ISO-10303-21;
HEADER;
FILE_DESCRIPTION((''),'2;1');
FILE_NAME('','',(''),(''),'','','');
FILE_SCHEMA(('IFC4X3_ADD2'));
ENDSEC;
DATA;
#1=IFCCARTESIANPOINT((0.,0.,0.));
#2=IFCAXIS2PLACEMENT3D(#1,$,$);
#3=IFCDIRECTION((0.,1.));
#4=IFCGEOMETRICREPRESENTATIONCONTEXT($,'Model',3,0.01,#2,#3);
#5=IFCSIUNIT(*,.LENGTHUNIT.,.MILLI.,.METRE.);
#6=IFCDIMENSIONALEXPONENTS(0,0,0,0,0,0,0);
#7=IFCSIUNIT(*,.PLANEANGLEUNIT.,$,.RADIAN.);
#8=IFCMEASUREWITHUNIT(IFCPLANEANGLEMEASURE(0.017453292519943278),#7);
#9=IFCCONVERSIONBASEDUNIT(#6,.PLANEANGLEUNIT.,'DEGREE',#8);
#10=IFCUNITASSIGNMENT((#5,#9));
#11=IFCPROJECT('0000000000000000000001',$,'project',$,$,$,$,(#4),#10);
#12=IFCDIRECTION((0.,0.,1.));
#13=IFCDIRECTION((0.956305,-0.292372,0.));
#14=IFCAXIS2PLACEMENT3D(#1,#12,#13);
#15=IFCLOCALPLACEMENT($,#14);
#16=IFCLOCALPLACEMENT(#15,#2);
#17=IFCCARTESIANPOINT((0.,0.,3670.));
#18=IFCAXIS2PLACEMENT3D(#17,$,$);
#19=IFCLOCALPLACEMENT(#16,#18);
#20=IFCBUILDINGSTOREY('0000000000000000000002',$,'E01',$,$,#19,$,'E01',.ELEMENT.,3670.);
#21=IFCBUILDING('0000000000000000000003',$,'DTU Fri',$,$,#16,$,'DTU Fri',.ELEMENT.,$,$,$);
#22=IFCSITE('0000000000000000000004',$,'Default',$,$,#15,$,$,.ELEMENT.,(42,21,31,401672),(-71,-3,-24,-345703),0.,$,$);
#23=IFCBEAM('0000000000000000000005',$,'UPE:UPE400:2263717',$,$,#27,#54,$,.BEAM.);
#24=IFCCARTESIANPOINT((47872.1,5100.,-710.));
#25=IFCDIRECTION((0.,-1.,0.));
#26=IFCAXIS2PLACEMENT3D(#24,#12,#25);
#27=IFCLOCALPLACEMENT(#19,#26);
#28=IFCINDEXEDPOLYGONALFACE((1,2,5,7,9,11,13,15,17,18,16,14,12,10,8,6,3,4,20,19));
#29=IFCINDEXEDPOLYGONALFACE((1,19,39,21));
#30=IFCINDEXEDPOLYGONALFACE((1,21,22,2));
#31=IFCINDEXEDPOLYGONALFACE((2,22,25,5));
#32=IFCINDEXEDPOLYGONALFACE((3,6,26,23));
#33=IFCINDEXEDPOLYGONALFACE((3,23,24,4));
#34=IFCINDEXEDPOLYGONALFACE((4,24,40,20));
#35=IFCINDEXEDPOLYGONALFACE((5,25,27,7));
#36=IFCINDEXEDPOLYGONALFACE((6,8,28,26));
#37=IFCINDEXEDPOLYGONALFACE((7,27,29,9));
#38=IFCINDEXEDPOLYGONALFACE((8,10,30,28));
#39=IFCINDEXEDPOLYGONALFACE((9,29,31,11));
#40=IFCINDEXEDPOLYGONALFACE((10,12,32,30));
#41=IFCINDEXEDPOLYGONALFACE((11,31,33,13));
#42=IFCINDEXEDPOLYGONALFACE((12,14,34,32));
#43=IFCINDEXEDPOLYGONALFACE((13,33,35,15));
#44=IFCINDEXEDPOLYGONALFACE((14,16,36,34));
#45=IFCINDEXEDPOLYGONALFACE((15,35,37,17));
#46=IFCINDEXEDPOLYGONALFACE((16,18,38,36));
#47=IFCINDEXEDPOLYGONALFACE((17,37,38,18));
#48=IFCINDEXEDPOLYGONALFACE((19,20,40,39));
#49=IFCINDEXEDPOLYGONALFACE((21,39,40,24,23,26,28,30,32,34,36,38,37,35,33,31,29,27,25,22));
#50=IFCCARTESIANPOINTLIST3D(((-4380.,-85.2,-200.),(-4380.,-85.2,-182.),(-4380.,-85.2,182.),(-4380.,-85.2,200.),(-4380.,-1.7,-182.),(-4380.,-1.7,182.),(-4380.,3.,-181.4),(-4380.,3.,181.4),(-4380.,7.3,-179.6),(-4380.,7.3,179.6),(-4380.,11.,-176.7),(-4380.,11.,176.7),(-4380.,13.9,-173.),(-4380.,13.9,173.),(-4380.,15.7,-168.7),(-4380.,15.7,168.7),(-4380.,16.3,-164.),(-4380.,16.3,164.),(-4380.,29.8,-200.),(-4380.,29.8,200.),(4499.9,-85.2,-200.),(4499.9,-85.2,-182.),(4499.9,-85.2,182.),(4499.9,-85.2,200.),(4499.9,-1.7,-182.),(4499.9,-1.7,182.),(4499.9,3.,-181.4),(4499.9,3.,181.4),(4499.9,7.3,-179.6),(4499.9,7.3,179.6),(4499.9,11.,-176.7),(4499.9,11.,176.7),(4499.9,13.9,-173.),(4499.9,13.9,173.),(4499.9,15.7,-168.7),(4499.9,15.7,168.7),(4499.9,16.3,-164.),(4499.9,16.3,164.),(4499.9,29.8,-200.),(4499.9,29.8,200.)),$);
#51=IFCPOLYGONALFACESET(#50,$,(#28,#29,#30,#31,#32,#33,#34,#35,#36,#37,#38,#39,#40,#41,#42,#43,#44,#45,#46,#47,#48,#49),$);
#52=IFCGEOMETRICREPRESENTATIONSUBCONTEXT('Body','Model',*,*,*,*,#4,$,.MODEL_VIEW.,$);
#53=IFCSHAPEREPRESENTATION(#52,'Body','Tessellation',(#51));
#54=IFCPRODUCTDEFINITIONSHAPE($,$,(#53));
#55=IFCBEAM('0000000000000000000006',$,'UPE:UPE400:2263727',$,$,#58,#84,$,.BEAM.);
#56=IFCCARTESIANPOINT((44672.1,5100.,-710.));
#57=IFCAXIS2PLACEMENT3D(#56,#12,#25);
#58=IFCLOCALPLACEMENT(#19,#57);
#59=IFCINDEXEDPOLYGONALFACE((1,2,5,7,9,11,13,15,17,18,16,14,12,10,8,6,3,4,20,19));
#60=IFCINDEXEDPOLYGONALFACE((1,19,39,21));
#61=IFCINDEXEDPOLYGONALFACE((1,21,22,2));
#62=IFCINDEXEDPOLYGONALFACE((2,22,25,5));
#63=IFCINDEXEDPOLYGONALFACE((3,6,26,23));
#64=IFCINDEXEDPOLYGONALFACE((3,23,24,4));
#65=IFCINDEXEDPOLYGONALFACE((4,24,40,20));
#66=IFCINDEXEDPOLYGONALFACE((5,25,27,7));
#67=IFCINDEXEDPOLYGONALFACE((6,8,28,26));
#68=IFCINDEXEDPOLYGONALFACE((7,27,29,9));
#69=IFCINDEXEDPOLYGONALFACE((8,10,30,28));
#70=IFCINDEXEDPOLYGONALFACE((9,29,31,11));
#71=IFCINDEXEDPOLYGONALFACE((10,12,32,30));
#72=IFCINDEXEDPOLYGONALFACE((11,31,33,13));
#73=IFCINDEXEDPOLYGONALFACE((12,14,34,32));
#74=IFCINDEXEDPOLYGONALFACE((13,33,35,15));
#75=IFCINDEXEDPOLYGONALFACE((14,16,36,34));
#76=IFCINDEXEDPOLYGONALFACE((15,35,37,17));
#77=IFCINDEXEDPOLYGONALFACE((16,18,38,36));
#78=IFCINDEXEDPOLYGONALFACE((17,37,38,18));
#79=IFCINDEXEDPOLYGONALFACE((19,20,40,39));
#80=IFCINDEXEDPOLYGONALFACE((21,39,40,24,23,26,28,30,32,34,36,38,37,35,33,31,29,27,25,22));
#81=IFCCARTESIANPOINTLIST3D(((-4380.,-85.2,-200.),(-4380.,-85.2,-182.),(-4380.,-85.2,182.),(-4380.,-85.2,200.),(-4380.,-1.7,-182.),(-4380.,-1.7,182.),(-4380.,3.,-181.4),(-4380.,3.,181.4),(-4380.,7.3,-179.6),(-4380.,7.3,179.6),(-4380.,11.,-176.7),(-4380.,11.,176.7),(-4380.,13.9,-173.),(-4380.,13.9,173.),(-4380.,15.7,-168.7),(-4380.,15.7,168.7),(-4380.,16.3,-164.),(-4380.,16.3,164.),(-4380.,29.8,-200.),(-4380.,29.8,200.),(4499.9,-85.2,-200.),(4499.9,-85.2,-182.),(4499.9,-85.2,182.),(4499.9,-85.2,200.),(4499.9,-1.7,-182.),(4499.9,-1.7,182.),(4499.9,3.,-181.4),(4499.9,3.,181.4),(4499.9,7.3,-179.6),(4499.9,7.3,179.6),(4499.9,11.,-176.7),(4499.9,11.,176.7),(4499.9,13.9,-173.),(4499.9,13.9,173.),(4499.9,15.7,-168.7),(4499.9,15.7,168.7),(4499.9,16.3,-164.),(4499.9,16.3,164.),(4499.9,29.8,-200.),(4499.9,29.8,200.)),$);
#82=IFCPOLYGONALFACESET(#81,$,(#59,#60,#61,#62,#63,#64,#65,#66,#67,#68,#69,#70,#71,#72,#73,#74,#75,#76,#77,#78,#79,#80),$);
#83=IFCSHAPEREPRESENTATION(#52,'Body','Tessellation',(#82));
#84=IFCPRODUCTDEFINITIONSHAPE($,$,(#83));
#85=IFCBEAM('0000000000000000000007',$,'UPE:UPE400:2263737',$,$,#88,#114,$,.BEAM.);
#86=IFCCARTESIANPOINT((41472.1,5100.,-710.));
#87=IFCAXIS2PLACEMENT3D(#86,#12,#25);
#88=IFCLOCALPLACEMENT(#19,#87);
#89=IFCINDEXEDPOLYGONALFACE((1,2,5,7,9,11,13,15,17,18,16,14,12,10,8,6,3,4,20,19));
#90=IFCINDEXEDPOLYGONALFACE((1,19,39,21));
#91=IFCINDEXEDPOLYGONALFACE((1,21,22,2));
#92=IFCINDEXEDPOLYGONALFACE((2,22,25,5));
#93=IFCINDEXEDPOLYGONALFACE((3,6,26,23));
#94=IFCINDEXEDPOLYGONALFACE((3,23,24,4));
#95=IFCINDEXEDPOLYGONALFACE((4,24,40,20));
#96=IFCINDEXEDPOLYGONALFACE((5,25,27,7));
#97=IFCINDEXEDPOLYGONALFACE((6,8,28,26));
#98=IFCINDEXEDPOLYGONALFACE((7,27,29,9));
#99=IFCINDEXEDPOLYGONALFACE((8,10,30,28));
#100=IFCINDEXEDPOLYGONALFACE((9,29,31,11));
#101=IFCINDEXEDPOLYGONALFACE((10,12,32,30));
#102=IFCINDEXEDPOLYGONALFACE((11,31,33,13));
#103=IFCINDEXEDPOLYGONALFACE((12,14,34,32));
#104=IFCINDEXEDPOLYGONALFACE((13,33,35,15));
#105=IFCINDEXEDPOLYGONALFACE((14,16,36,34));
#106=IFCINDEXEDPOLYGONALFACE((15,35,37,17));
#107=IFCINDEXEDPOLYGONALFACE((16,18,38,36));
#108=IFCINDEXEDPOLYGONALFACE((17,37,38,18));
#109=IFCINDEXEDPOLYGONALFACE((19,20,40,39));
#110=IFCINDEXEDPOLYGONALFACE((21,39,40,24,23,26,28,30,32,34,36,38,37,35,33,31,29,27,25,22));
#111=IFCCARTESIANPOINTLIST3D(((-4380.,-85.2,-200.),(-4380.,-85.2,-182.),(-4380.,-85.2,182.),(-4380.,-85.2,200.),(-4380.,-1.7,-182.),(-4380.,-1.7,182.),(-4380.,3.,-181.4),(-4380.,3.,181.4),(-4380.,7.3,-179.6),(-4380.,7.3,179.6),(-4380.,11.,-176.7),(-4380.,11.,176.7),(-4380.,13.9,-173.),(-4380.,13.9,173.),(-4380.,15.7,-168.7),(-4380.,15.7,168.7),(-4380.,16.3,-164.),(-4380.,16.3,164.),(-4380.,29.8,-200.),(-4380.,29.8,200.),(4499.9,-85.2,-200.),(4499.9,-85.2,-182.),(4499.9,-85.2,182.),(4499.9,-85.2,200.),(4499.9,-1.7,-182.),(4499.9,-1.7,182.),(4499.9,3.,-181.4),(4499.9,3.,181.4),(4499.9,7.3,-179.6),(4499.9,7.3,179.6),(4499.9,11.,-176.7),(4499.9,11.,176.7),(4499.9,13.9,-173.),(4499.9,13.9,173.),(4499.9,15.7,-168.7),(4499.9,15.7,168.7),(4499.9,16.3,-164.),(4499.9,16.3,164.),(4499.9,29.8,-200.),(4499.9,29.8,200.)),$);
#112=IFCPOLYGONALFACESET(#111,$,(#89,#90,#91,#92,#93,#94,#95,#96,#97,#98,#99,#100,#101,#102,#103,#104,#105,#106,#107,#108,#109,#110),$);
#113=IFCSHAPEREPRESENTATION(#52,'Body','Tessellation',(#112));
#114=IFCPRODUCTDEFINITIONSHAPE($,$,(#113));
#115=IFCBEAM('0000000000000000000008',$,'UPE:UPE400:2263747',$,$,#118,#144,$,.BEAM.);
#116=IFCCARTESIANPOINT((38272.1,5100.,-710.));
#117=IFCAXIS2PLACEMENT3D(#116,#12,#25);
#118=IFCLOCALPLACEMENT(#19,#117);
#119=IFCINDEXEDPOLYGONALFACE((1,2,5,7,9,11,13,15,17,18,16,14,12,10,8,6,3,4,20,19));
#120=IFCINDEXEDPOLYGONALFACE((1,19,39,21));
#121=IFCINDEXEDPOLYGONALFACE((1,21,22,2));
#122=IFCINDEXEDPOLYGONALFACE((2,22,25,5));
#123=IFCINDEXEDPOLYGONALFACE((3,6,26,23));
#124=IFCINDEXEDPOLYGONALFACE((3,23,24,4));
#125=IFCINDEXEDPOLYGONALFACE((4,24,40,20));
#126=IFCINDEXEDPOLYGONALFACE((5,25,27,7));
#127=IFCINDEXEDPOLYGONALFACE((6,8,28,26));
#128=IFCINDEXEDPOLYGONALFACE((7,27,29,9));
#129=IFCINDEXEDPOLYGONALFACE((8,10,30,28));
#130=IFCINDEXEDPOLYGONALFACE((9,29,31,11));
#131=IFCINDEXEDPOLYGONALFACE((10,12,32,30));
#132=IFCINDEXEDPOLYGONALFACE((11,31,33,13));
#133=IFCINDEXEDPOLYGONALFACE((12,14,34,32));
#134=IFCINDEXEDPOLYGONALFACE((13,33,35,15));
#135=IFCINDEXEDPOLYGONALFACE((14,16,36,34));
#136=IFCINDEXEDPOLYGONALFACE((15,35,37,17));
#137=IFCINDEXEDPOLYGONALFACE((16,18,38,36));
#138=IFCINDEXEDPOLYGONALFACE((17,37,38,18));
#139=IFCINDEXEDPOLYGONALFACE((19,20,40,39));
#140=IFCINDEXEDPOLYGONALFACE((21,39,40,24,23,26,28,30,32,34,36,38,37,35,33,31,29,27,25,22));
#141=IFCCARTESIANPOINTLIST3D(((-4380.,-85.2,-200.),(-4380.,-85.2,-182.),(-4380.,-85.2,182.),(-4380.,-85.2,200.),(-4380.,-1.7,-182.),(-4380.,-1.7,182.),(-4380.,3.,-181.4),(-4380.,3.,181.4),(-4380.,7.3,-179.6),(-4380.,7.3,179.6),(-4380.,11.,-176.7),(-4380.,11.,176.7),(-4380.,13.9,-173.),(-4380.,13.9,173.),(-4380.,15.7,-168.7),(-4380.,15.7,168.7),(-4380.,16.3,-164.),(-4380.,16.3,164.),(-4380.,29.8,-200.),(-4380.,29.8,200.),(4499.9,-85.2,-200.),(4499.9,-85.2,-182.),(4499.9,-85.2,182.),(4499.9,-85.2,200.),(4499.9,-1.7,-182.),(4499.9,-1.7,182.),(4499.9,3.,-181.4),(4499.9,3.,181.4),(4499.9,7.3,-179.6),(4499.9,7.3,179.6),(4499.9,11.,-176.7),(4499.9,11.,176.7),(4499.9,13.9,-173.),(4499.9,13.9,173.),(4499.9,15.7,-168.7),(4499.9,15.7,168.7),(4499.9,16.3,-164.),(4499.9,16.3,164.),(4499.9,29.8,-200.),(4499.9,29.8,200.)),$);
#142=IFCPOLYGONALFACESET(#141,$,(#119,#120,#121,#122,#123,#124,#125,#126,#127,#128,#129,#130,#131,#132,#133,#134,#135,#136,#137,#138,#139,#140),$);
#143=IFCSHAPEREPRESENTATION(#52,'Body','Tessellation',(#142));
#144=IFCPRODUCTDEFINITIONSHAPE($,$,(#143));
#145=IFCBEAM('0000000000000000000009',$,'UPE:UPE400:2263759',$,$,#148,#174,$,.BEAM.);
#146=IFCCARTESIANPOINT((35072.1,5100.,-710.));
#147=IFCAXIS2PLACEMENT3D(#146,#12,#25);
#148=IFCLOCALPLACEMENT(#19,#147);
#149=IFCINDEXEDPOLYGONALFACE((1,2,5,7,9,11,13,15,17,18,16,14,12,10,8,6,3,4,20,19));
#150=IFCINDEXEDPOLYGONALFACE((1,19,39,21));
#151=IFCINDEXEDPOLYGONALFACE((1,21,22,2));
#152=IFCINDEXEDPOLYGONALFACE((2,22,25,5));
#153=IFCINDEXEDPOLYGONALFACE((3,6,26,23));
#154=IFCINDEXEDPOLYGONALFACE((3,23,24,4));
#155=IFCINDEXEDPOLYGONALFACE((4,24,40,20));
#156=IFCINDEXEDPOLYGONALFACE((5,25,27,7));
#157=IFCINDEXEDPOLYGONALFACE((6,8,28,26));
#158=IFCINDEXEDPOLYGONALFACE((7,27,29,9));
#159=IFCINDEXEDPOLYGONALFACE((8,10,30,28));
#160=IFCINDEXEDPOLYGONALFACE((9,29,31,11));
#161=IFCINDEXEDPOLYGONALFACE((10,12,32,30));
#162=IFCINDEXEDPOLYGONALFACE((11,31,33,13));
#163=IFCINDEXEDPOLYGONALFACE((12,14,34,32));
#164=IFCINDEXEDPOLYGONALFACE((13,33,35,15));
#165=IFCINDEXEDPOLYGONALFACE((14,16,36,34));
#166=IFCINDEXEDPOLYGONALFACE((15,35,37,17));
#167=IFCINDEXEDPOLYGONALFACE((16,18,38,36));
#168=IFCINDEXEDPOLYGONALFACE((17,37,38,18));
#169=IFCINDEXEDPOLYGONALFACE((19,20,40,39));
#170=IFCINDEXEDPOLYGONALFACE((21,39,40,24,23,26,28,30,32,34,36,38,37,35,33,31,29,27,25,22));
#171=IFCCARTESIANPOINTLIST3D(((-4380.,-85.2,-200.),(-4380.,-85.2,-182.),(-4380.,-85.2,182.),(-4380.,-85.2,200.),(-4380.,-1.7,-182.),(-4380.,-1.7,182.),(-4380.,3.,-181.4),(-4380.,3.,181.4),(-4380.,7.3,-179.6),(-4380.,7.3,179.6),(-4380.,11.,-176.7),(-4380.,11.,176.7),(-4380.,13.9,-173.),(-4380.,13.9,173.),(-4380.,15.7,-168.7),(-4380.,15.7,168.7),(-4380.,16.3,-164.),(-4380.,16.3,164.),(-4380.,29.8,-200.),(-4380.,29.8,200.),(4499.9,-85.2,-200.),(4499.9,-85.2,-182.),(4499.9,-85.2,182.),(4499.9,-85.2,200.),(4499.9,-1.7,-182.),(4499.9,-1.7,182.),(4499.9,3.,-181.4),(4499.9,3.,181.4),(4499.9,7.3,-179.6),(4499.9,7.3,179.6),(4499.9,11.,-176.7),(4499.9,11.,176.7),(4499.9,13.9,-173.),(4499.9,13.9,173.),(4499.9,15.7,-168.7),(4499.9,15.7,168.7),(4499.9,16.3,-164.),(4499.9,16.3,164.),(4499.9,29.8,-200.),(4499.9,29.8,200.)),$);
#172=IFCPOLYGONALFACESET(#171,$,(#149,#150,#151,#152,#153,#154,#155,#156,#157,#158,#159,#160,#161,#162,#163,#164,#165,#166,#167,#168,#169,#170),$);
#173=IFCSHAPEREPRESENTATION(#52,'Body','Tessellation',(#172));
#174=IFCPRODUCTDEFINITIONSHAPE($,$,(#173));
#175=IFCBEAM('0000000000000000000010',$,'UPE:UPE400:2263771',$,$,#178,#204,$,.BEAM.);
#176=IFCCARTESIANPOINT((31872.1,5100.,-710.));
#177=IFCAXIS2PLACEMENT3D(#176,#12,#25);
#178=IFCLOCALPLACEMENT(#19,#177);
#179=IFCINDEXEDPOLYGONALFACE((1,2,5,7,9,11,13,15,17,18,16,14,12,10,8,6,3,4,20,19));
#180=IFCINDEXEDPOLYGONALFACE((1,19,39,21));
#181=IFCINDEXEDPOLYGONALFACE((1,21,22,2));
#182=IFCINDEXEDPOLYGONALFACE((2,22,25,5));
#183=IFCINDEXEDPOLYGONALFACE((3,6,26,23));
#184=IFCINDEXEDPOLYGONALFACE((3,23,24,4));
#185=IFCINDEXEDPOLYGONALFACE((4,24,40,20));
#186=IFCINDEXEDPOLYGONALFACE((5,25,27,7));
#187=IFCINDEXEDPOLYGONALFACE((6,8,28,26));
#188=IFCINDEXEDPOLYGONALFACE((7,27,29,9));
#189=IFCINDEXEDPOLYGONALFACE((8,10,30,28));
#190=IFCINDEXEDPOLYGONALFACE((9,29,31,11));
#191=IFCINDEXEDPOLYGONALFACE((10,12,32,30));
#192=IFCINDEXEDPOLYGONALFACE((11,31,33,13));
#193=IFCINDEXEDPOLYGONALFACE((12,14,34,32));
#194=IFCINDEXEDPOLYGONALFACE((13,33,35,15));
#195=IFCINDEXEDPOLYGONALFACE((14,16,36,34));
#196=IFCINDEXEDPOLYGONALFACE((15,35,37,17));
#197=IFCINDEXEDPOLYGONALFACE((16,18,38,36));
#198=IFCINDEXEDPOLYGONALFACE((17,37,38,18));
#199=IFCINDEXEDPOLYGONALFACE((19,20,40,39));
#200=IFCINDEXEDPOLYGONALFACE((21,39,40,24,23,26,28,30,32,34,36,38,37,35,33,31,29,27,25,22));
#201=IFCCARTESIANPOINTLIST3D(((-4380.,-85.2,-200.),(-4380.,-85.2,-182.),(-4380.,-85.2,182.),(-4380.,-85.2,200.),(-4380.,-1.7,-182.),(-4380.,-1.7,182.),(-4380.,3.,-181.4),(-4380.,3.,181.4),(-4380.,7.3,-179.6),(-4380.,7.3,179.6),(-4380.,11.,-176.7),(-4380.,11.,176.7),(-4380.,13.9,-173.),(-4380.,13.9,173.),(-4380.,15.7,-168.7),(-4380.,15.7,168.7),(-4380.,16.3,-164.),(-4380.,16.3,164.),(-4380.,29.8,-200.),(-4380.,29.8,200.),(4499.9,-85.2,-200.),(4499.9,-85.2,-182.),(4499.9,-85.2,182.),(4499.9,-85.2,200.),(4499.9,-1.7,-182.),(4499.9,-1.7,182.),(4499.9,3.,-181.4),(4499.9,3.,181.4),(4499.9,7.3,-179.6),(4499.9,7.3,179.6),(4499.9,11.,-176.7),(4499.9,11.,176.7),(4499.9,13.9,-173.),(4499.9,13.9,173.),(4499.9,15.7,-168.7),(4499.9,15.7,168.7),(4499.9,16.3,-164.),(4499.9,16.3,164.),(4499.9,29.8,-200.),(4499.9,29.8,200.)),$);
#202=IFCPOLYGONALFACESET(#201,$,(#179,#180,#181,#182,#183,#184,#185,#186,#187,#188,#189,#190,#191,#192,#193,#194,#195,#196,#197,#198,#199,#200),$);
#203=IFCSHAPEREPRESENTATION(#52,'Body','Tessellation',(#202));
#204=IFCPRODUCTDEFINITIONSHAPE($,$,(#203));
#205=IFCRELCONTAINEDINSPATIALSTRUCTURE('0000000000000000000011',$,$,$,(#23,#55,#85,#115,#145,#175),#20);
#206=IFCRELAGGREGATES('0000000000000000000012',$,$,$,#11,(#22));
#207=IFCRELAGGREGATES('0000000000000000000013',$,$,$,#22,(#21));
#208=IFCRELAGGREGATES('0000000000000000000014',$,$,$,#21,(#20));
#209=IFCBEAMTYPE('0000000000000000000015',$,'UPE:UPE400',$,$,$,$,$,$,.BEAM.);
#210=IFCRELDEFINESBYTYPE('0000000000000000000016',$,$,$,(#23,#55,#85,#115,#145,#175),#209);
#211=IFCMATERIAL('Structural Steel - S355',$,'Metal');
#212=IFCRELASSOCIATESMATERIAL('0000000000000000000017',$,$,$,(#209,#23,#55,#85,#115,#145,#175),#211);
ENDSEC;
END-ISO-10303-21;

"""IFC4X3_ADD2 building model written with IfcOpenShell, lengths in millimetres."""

from ifc_helpers import new_model, entity, si_unit, converted_unit, direction, frame, frame_2d, origin, place, context, subcontext, project, spatial, polyline, circle_curve, parameter, trimmed, segment, composite_curve, outline, extrude, source, transform, mapped, material, material_profile, profile_set, profile_usage, type_object, type_shapes, element, save


model = new_model("IFC4X3_ADD2")

# Units and contexts
model_context = context("Model", 3, precision=0.01, world=origin(), true_north=direction((0.0, 1.0)))
body_context = subcontext(model_context, "Body", "Model", "MODEL_VIEW")
ifc_project = project(units=[si_unit("LENGTHUNIT", "METRE", prefix="MILLI"), converted_unit("PLANEANGLEUNIT", "DEGREE", entity("IfcPlaneAngleMeasure", 0.017453292519943278), si_unit("PLANEANGLEUNIT", "RADIAN"), dimensions=[0, 0, 0, 0, 0, 0, 0])], contexts=[model_context])

# Site, building, storey
site_placement = place(None, frame((0.0, 0.0, 0.0), z_axis=(0.0, 0.0, 1.0), x_axis=(0.956305, -0.292372, 0.0)))
site = spatial("IfcSite", under=ifc_project, at=site_placement, Name="Default", CompositionType="ELEMENT", RefLatitude=(42, 21, 31, 401672), RefLongitude=(-71, -3, -24, -345703), RefElevation=0.0)
building_placement = place(site_placement, origin())
building = spatial("IfcBuilding", under=site, at=building_placement, Name="DTU Fri", LongName="DTU Fri", CompositionType="ELEMENT")
storey_placement = place(building_placement, frame((0.0, 0.0, 3670.0)))
storey = spatial("IfcBuildingStorey", under=building, at=storey_placement, Name="E01", LongName="E01", CompositionType="ELEMENT", Elevation=3670.0)

# Beams
ifc_material_1 = material(Name="Structural Steel - S355", Category="Metal")
ifc_material_profile_1 = material_profile(ifc_material_1, outline(composite_curve([segment(polyline([(-200.0, -60.0), (-182.0, -60.0)]), True, "CONTINUOUS"), segment(polyline([(-182.0, -60.0), (-182.0, 23.5)]), True, "CONTINUOUS"), segment(trimmed(circle_curve(frame_2d((-164.0, 23.5), x_axis=(-1.0, 0.0)), 18.0), [parameter(270.0)], [parameter(0.0)], True, "PARAMETER"), False, "CONTINUOUS"), segment(polyline([(-164.0, 41.5), (164.0, 41.5)]), True, "CONTINUOUS"), segment(trimmed(circle_curve(frame_2d((164.0, 23.5), x_axis=(0.0, 1.0)), 18.0), [parameter(270.0)], [parameter(0.0)], True, "PARAMETER"), False, "CONTINUOUS"), segment(polyline([(182.0, 23.5), (182.0, -60.0)]), True, "CONTINUOUS"), segment(polyline([(182.0, -60.0), (200.0, -60.0)]), True, "CONTINUOUS"), segment(polyline([(200.0, -60.0), (200.0, 55.0)]), True, "CONTINUOUS"), segment(polyline([(200.0, 55.0), (-200.0, 55.0)]), True, "CONTINUOUS"), segment(polyline([(-200.0, 55.0), (-200.0, -60.0)]), True, "CONTINUOUS")], self_intersect=False)), Name="UPE400")
ifc_profile_set_1 = profile_set([ifc_material_profile_1], Name="UPE400")
ifc_profile_usage_1 = profile_usage(ifc_profile_set_1, cardinal=8)
beam_type_1 = type_object("IfcBeamType", Name="UPE:UPE400", PredefinedType="BEAM", material=ifc_profile_set_1)
shared_shape_1 = source(origin(), body_context, "Body", "SweptSolid", [
    extrude(outline(composite_curve([segment(polyline([(-200.0, -60.0), (-182.0, -60.0)]), True, "CONTINUOUS"), segment(polyline([(-182.0, -60.0), (-182.0, 23.5)]), True, "CONTINUOUS"), segment(trimmed(circle_curve(frame_2d((-164.0, 23.5), x_axis=(-1.0, 0.0)), 18.0), [parameter(270.0)], [parameter(0.0)], True, "PARAMETER"), False, "CONTINUOUS"), segment(polyline([(-164.0, 41.5), (164.0, 41.5)]), True, "CONTINUOUS"), segment(trimmed(circle_curve(frame_2d((164.0, 23.5), x_axis=(0.0, 1.0)), 18.0), [parameter(270.0)], [parameter(0.0)], True, "PARAMETER"), False, "CONTINUOUS"), segment(polyline([(182.0, 23.5), (182.0, -60.0)]), True, "CONTINUOUS"), segment(polyline([(182.0, -60.0), (200.0, -60.0)]), True, "CONTINUOUS"), segment(polyline([(200.0, -60.0), (200.0, 55.0)]), True, "CONTINUOUS"), segment(polyline([(200.0, 55.0), (-200.0, 55.0)]), True, "CONTINUOUS"), segment(polyline([(-200.0, 55.0), (-200.0, -60.0)]), True, "CONTINUOUS")], self_intersect=False)), frame((-4380.0, -25.2, 0.0), z_axis=(1.0, 0.0, 0.0), x_axis=(0.0, 0.0, -1.0)), (0.0, 0.0, 1.0), 8879.9),
])
type_shapes(beam_type_1, [shared_shape_1])
for number, where, z_axis, x_axis, name in (
    (1, (47872.1, 5100.0, -710.0), (0.0, 0.0, 1.0), (0.0, -1.0, 0.0), "UPE:UPE400:2263717"),
    (2, (44672.1, 5100.0, -710.0), (0.0, 0.0, 1.0), (0.0, -1.0, 0.0), "UPE:UPE400:2263727"),
    (3, (41472.1, 5100.0, -710.0), (0.0, 0.0, 1.0), (0.0, -1.0, 0.0), "UPE:UPE400:2263737"),
    (4, (38272.1, 5100.0, -710.0), (0.0, 0.0, 1.0), (0.0, -1.0, 0.0), "UPE:UPE400:2263747"),
    (5, (35072.1, 5100.0, -710.0), (0.0, 0.0, 1.0), (0.0, -1.0, 0.0), "UPE:UPE400:2263759"),
    (6, (31872.1, 5100.0, -710.0), (0.0, 0.0, 1.0), (0.0, -1.0, 0.0), "UPE:UPE400:2263771"),
):
    element("IfcBeam", number, at=place(storey_placement, frame(where, z_axis=z_axis, x_axis=x_axis)), inside=storey, type_object=beam_type_1, material=ifc_profile_usage_1, Name=name, PredefinedType="BEAM", context=body_context, shape_type="MappedRepresentation", body=[
        mapped(shared_shape_1, transform((0.0, 0.0, 0.0), scale=1.0)),
    ])

save(model, "model.ifc")
